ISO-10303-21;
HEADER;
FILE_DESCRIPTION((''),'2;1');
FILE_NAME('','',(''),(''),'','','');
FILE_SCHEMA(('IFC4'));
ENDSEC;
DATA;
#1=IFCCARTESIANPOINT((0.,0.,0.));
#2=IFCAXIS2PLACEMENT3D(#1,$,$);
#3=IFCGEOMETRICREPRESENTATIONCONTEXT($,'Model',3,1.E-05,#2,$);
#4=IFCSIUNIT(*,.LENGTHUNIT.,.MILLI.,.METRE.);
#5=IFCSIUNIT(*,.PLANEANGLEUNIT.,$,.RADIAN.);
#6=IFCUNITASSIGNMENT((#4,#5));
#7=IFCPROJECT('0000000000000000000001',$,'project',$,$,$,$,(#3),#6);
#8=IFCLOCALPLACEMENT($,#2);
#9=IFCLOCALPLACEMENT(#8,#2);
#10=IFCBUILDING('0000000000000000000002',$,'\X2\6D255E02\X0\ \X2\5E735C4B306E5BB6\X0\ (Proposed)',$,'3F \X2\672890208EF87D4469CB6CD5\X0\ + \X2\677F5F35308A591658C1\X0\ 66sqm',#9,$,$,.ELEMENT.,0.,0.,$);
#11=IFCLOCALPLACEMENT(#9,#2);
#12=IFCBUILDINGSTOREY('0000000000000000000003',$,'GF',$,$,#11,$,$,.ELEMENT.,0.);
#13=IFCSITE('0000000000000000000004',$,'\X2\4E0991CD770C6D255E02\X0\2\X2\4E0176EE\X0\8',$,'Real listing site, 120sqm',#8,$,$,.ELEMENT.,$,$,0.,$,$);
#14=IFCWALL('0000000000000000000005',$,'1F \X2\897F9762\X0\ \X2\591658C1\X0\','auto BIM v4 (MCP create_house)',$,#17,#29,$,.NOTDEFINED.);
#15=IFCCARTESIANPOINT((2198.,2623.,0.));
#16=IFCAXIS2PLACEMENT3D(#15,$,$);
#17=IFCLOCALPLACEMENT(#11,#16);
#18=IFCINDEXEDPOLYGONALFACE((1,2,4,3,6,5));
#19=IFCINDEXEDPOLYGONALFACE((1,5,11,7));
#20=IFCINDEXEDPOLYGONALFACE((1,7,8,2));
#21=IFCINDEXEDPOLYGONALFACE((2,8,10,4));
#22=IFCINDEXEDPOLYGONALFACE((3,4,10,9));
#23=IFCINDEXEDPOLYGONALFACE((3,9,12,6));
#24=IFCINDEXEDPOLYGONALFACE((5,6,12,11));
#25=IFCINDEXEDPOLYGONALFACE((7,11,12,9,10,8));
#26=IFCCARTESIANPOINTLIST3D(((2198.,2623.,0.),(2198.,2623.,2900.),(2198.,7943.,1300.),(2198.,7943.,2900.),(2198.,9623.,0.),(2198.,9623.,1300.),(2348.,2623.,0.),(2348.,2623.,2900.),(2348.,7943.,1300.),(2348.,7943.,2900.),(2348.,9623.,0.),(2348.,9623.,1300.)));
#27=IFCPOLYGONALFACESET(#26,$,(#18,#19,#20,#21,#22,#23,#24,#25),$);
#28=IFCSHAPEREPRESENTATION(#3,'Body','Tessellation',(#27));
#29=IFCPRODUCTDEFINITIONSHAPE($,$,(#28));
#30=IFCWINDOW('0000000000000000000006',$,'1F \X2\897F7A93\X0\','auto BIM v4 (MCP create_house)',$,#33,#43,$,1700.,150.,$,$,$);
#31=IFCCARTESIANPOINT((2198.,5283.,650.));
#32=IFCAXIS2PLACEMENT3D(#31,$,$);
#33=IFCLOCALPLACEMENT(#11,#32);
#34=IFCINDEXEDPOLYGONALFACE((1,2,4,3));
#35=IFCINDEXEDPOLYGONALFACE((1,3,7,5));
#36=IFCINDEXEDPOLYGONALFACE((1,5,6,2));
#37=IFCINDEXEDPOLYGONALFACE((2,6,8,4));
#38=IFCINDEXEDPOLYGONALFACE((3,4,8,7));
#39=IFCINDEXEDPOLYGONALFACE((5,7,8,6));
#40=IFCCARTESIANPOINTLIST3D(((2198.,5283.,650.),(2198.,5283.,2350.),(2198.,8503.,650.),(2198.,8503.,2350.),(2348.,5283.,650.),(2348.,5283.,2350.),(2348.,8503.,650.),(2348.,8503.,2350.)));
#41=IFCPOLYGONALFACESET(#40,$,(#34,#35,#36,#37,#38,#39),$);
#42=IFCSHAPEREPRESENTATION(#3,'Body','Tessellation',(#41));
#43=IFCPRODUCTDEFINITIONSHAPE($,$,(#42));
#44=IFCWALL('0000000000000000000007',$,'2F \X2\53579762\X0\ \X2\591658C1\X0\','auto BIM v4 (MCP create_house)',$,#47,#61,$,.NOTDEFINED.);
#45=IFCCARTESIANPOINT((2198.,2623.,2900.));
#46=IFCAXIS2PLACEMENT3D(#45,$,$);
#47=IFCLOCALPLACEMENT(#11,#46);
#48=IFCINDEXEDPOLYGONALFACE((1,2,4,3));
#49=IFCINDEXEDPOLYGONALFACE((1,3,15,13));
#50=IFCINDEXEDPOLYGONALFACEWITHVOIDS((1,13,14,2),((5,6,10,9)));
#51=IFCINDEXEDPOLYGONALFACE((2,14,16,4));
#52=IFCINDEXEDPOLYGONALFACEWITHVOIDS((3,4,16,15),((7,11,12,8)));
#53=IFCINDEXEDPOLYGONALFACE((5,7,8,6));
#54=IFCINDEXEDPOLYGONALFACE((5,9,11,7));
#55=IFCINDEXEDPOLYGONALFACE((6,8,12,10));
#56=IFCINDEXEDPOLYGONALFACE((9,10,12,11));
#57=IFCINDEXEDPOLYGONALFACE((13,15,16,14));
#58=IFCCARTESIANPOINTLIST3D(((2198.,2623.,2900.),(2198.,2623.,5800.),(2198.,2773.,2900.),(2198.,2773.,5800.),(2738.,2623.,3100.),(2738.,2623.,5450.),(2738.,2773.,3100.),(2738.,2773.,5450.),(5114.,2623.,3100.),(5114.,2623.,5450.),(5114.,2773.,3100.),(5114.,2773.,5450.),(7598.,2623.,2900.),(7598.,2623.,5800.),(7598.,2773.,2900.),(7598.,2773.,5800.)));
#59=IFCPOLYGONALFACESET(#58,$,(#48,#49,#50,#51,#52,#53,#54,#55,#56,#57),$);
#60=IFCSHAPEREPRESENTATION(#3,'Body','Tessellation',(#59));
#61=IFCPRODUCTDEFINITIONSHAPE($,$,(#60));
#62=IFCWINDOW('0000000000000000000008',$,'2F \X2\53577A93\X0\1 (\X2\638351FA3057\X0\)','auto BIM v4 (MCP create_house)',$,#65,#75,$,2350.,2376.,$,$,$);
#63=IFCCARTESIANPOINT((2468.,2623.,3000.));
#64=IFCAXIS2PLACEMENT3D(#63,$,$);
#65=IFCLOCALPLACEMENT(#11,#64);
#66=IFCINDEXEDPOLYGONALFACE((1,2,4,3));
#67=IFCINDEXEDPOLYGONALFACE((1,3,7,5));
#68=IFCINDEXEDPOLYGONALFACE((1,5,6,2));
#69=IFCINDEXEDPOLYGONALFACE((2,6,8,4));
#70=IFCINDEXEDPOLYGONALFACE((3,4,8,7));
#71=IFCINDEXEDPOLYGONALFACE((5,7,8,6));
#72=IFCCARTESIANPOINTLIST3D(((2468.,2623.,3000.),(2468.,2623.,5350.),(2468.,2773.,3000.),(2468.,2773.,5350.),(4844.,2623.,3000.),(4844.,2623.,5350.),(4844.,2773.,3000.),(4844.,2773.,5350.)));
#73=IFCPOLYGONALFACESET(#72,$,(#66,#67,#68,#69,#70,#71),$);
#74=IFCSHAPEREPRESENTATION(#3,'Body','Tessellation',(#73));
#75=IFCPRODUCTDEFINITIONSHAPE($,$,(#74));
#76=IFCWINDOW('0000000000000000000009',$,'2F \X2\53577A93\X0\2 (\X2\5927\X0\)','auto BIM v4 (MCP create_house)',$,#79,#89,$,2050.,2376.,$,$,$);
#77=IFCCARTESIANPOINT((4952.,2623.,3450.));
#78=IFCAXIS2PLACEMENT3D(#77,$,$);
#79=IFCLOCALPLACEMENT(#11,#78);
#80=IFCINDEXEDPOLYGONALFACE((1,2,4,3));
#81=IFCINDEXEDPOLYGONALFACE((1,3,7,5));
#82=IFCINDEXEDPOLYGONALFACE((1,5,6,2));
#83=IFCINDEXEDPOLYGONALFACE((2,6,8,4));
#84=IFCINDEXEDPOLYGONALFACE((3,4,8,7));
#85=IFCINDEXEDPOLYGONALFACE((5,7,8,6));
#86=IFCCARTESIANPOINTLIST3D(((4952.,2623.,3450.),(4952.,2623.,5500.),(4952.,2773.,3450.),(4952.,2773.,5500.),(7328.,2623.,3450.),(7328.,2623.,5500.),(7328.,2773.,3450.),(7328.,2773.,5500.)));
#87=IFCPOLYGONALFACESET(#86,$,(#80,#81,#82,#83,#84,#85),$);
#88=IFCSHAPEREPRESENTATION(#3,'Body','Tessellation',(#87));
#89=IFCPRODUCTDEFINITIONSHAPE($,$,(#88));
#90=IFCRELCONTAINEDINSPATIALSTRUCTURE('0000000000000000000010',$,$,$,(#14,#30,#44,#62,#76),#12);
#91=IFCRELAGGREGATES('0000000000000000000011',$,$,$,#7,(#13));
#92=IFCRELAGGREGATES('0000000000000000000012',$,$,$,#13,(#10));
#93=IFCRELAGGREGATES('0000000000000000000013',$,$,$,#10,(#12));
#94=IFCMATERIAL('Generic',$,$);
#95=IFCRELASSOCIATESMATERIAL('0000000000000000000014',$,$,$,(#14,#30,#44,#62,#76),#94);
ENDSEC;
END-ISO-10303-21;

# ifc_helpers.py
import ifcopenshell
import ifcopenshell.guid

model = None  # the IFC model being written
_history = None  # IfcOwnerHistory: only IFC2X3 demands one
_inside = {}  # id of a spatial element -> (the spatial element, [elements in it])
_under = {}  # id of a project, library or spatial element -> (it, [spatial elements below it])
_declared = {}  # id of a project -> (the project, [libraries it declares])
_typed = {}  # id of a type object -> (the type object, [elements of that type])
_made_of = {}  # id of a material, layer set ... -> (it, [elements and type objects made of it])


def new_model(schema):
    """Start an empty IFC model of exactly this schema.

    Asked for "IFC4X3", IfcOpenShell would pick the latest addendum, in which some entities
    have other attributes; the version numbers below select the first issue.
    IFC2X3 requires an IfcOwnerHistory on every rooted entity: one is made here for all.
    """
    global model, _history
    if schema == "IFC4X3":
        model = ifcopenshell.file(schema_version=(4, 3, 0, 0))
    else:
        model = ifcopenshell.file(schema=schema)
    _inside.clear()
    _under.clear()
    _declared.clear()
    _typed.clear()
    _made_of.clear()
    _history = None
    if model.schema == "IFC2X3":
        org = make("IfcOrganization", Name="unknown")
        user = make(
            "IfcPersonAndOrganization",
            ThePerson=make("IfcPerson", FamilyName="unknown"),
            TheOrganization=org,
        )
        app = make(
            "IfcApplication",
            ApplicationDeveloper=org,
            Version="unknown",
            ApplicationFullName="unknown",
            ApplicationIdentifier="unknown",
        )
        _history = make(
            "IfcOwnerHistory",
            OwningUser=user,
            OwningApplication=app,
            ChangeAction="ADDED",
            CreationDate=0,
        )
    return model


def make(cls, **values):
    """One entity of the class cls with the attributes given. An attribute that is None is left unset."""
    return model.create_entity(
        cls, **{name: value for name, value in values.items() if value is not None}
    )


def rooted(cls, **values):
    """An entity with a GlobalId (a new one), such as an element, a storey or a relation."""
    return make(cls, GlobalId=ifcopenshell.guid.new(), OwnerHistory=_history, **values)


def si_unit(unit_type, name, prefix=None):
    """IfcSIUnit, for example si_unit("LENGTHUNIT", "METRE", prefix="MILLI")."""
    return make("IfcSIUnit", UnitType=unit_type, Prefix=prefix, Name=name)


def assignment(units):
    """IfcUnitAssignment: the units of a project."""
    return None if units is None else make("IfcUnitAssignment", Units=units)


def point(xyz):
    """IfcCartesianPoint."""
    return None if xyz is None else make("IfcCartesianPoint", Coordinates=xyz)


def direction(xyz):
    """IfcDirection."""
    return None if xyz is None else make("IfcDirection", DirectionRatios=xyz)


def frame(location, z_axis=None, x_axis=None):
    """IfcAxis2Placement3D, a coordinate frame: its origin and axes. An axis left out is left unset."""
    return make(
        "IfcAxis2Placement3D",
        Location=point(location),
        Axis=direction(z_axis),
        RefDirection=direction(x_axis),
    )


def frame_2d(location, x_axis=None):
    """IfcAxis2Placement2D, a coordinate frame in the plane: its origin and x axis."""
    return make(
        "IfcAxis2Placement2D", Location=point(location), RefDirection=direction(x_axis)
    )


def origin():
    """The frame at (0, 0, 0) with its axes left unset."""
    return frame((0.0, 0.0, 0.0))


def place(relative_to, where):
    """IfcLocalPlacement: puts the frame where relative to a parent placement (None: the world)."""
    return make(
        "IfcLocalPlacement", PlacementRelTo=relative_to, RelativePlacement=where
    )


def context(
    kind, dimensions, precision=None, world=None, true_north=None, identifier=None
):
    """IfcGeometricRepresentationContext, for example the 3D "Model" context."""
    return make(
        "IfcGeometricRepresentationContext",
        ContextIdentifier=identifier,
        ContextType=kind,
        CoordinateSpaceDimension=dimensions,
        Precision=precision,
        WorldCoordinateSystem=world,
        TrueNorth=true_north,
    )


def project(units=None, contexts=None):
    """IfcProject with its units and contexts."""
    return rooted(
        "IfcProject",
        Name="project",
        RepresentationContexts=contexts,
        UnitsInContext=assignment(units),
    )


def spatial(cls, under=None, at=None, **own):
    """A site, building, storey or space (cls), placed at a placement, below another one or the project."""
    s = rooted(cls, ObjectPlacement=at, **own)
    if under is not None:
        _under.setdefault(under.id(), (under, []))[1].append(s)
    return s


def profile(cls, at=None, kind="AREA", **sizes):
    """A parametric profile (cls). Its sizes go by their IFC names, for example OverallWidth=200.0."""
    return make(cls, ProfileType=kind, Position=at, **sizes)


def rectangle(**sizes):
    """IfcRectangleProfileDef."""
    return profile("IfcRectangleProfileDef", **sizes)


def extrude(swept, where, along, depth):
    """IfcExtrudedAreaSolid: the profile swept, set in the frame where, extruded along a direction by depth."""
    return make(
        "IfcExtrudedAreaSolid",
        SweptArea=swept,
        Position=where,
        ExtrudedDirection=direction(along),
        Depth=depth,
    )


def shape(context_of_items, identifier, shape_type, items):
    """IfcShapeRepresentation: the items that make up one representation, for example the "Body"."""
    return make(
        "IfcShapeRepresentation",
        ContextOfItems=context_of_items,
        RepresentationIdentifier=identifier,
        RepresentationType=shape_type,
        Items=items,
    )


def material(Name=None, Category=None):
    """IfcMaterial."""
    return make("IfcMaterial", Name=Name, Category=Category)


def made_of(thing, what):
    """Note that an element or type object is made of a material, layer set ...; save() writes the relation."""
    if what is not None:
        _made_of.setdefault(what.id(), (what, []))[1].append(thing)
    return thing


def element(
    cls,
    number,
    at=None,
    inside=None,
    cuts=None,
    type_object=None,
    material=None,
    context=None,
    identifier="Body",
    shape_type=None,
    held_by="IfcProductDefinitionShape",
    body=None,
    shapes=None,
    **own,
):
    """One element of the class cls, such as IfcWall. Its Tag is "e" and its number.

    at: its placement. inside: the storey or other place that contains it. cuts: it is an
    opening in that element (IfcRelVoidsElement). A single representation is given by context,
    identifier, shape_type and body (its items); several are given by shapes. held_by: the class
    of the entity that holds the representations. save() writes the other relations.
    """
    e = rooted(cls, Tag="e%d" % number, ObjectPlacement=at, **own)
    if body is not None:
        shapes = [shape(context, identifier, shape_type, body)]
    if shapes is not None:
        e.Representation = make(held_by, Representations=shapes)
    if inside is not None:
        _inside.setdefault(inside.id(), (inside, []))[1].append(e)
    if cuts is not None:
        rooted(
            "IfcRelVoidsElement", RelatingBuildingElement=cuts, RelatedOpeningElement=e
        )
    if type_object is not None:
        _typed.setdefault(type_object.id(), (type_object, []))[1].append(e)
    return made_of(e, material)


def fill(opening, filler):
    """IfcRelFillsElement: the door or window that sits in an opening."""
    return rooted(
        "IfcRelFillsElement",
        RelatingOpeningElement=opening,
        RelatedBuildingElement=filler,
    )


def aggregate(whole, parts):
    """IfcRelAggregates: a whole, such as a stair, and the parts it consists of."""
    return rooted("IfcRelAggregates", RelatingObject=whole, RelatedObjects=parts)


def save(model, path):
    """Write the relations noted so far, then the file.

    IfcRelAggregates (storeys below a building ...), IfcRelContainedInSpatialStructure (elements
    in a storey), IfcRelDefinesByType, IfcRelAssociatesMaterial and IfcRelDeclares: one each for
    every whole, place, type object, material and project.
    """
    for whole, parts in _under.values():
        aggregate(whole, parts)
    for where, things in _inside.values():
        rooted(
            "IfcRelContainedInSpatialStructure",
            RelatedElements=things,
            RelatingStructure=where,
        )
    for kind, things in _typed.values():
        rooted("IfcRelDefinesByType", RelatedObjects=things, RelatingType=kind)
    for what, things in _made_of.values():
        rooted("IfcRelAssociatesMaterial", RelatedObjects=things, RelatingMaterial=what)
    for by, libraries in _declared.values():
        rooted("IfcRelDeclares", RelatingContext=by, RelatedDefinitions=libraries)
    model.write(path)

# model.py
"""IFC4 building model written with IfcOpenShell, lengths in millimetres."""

from ifc_helpers import new_model, si_unit, frame, frame_2d, origin, place, context, project, spatial, rectangle, extrude, material, element, fill, save


model = new_model("IFC4")

# Units and contexts
model_context = context("Model", 3, precision=1e-05, world=origin())
ifc_project = project(units=[si_unit("LENGTHUNIT", "METRE", prefix="MILLI"), si_unit("PLANEANGLEUNIT", "RADIAN")], contexts=[model_context])

# Site, building, storey
site_placement = place(None, origin())
site = spatial("IfcSite", under=ifc_project, at=site_placement, Name="三重県津市2丁目8", ObjectType="Real listing site, 120sqm", CompositionType="ELEMENT", RefElevation=0.0)
building_placement = place(site_placement, origin())
building = spatial("IfcBuilding", under=site, at=building_placement, Name="津市 平屋の家 (Proposed)", ObjectType="3F 木造軸組構法 + 板張り外壁 66sqm", CompositionType="ELEMENT", ElevationOfRefHeight=0.0, ElevationOfTerrain=0.0)
storey_placement = place(building_placement, origin())
storey = spatial("IfcBuildingStorey", under=building, at=storey_placement, Name="GF", CompositionType="ELEMENT", Elevation=0.0)

# Shared definitions
ifc_material = material(Name="Generic")

# Wall, opening, window
wall_1_placement = place(storey_placement, frame((2198.0, 2623.0, 0.0)))
wall_1 = element("IfcWall", 1, at=wall_1_placement, inside=storey, material=ifc_material, Name="1F 西面 外壁", Description="auto BIM v4 (MCP create_house)", PredefinedType="NOTDEFINED", context=model_context, shape_type="SweptSolid", body=[
    extrude(rectangle(XDim=150.0, YDim=7000.0, at=frame_2d((75.0, 3500.0))), frame((2198.0, 2623.0, 0.0)), (0.0, 0.0, 1.0), 2900.0),
])
opening_1_placement = place(storey_placement, frame((2198.0, 5283.0, 650.0)))
opening_1 = element("IfcOpeningElement", 2, at=opening_1_placement, cuts=wall_1, PredefinedType="NOTDEFINED", context=model_context, shape_type="SweptSolid", body=[
    extrude(rectangle(XDim=150.0, YDim=3220.0, at=frame_2d((75.0, 1610.0))), frame((2198.0, 5283.0, 650.0)), (0.0, 0.0, 1.0), 1700.0),
])
window_1_placement = place(storey_placement, frame((2198.0, 5283.0, 650.0)))
window_1 = element("IfcWindow", 3, at=window_1_placement, inside=storey, material=ifc_material, Name="1F 西窓", Description="auto BIM v4 (MCP create_house)", OverallHeight=1700.0, OverallWidth=150.0, context=model_context, shape_type="SweptSolid", body=[
    extrude(rectangle(XDim=150.0, YDim=3220.0, at=frame_2d((75.0, 1610.0))), frame((2198.0, 5283.0, 650.0)), (0.0, 0.0, 1.0), 1700.0),
])
fill(opening_1, window_1)

# Wall, openings, windows
wall_2_placement = place(storey_placement, frame((2198.0, 2623.0, 2900.0)))
wall_2 = element("IfcWall", 4, at=wall_2_placement, inside=storey, material=ifc_material, Name="2F 南面 外壁", Description="auto BIM v4 (MCP create_house)", PredefinedType="NOTDEFINED", context=model_context, shape_type="SweptSolid", body=[
    extrude(rectangle(XDim=5400.0, YDim=150.0, at=frame_2d((2700.0, 75.0))), frame((2198.0, 2623.0, 2900.0)), (0.0, 0.0, 1.0), 2900.0),
])
opening_2_placement = place(storey_placement, frame((2468.0, 2623.0, 3000.0)))
opening_2 = element("IfcOpeningElement", 5, at=opening_2_placement, cuts=wall_2, PredefinedType="NOTDEFINED", context=model_context, shape_type="SweptSolid", body=[
    extrude(rectangle(XDim=2376.0, YDim=150.0, at=frame_2d((1188.0, 75.0))), frame((2468.0, 2623.0, 3000.0)), (0.0, 0.0, 1.0), 2350.0),
])
opening_3_placement = place(storey_placement, frame((4952.0, 2623.0, 3450.0)))
opening_3 = element("IfcOpeningElement", 6, at=opening_3_placement, cuts=wall_2, PredefinedType="NOTDEFINED", context=model_context, shape_type="SweptSolid", body=[
    extrude(rectangle(XDim=2376.0, YDim=150.0, at=frame_2d((1188.0, 75.0))), frame((4952.0, 2623.0, 3450.0)), (0.0, 0.0, 1.0), 2050.0),
])
window_2_placement = place(storey_placement, frame((2468.0, 2623.0, 3000.0)))
window_2 = element("IfcWindow", 7, at=window_2_placement, inside=storey, material=ifc_material, Name="2F 南窓1 (掃出し)", Description="auto BIM v4 (MCP create_house)", OverallHeight=2350.0, OverallWidth=2376.0, context=model_context, shape_type="SweptSolid", body=[
    extrude(rectangle(XDim=2376.0, YDim=150.0, at=frame_2d((1188.0, 75.0))), frame((2468.0, 2623.0, 3000.0)), (0.0, 0.0, 1.0), 2350.0),
])
fill(opening_2, window_2)
window_3_placement = place(storey_placement, frame((4952.0, 2623.0, 3450.0)))
window_3 = element("IfcWindow", 8, at=window_3_placement, inside=storey, material=ifc_material, Name="2F 南窓2 (大)", Description="auto BIM v4 (MCP create_house)", OverallHeight=2050.0, OverallWidth=2376.0, context=model_context, shape_type="SweptSolid", body=[
    extrude(rectangle(XDim=2376.0, YDim=150.0, at=frame_2d((1188.0, 75.0))), frame((4952.0, 2623.0, 3450.0)), (0.0, 0.0, 1.0), 2050.0),
])
fill(opening_3, window_3)

save(model, "model.ifc")
